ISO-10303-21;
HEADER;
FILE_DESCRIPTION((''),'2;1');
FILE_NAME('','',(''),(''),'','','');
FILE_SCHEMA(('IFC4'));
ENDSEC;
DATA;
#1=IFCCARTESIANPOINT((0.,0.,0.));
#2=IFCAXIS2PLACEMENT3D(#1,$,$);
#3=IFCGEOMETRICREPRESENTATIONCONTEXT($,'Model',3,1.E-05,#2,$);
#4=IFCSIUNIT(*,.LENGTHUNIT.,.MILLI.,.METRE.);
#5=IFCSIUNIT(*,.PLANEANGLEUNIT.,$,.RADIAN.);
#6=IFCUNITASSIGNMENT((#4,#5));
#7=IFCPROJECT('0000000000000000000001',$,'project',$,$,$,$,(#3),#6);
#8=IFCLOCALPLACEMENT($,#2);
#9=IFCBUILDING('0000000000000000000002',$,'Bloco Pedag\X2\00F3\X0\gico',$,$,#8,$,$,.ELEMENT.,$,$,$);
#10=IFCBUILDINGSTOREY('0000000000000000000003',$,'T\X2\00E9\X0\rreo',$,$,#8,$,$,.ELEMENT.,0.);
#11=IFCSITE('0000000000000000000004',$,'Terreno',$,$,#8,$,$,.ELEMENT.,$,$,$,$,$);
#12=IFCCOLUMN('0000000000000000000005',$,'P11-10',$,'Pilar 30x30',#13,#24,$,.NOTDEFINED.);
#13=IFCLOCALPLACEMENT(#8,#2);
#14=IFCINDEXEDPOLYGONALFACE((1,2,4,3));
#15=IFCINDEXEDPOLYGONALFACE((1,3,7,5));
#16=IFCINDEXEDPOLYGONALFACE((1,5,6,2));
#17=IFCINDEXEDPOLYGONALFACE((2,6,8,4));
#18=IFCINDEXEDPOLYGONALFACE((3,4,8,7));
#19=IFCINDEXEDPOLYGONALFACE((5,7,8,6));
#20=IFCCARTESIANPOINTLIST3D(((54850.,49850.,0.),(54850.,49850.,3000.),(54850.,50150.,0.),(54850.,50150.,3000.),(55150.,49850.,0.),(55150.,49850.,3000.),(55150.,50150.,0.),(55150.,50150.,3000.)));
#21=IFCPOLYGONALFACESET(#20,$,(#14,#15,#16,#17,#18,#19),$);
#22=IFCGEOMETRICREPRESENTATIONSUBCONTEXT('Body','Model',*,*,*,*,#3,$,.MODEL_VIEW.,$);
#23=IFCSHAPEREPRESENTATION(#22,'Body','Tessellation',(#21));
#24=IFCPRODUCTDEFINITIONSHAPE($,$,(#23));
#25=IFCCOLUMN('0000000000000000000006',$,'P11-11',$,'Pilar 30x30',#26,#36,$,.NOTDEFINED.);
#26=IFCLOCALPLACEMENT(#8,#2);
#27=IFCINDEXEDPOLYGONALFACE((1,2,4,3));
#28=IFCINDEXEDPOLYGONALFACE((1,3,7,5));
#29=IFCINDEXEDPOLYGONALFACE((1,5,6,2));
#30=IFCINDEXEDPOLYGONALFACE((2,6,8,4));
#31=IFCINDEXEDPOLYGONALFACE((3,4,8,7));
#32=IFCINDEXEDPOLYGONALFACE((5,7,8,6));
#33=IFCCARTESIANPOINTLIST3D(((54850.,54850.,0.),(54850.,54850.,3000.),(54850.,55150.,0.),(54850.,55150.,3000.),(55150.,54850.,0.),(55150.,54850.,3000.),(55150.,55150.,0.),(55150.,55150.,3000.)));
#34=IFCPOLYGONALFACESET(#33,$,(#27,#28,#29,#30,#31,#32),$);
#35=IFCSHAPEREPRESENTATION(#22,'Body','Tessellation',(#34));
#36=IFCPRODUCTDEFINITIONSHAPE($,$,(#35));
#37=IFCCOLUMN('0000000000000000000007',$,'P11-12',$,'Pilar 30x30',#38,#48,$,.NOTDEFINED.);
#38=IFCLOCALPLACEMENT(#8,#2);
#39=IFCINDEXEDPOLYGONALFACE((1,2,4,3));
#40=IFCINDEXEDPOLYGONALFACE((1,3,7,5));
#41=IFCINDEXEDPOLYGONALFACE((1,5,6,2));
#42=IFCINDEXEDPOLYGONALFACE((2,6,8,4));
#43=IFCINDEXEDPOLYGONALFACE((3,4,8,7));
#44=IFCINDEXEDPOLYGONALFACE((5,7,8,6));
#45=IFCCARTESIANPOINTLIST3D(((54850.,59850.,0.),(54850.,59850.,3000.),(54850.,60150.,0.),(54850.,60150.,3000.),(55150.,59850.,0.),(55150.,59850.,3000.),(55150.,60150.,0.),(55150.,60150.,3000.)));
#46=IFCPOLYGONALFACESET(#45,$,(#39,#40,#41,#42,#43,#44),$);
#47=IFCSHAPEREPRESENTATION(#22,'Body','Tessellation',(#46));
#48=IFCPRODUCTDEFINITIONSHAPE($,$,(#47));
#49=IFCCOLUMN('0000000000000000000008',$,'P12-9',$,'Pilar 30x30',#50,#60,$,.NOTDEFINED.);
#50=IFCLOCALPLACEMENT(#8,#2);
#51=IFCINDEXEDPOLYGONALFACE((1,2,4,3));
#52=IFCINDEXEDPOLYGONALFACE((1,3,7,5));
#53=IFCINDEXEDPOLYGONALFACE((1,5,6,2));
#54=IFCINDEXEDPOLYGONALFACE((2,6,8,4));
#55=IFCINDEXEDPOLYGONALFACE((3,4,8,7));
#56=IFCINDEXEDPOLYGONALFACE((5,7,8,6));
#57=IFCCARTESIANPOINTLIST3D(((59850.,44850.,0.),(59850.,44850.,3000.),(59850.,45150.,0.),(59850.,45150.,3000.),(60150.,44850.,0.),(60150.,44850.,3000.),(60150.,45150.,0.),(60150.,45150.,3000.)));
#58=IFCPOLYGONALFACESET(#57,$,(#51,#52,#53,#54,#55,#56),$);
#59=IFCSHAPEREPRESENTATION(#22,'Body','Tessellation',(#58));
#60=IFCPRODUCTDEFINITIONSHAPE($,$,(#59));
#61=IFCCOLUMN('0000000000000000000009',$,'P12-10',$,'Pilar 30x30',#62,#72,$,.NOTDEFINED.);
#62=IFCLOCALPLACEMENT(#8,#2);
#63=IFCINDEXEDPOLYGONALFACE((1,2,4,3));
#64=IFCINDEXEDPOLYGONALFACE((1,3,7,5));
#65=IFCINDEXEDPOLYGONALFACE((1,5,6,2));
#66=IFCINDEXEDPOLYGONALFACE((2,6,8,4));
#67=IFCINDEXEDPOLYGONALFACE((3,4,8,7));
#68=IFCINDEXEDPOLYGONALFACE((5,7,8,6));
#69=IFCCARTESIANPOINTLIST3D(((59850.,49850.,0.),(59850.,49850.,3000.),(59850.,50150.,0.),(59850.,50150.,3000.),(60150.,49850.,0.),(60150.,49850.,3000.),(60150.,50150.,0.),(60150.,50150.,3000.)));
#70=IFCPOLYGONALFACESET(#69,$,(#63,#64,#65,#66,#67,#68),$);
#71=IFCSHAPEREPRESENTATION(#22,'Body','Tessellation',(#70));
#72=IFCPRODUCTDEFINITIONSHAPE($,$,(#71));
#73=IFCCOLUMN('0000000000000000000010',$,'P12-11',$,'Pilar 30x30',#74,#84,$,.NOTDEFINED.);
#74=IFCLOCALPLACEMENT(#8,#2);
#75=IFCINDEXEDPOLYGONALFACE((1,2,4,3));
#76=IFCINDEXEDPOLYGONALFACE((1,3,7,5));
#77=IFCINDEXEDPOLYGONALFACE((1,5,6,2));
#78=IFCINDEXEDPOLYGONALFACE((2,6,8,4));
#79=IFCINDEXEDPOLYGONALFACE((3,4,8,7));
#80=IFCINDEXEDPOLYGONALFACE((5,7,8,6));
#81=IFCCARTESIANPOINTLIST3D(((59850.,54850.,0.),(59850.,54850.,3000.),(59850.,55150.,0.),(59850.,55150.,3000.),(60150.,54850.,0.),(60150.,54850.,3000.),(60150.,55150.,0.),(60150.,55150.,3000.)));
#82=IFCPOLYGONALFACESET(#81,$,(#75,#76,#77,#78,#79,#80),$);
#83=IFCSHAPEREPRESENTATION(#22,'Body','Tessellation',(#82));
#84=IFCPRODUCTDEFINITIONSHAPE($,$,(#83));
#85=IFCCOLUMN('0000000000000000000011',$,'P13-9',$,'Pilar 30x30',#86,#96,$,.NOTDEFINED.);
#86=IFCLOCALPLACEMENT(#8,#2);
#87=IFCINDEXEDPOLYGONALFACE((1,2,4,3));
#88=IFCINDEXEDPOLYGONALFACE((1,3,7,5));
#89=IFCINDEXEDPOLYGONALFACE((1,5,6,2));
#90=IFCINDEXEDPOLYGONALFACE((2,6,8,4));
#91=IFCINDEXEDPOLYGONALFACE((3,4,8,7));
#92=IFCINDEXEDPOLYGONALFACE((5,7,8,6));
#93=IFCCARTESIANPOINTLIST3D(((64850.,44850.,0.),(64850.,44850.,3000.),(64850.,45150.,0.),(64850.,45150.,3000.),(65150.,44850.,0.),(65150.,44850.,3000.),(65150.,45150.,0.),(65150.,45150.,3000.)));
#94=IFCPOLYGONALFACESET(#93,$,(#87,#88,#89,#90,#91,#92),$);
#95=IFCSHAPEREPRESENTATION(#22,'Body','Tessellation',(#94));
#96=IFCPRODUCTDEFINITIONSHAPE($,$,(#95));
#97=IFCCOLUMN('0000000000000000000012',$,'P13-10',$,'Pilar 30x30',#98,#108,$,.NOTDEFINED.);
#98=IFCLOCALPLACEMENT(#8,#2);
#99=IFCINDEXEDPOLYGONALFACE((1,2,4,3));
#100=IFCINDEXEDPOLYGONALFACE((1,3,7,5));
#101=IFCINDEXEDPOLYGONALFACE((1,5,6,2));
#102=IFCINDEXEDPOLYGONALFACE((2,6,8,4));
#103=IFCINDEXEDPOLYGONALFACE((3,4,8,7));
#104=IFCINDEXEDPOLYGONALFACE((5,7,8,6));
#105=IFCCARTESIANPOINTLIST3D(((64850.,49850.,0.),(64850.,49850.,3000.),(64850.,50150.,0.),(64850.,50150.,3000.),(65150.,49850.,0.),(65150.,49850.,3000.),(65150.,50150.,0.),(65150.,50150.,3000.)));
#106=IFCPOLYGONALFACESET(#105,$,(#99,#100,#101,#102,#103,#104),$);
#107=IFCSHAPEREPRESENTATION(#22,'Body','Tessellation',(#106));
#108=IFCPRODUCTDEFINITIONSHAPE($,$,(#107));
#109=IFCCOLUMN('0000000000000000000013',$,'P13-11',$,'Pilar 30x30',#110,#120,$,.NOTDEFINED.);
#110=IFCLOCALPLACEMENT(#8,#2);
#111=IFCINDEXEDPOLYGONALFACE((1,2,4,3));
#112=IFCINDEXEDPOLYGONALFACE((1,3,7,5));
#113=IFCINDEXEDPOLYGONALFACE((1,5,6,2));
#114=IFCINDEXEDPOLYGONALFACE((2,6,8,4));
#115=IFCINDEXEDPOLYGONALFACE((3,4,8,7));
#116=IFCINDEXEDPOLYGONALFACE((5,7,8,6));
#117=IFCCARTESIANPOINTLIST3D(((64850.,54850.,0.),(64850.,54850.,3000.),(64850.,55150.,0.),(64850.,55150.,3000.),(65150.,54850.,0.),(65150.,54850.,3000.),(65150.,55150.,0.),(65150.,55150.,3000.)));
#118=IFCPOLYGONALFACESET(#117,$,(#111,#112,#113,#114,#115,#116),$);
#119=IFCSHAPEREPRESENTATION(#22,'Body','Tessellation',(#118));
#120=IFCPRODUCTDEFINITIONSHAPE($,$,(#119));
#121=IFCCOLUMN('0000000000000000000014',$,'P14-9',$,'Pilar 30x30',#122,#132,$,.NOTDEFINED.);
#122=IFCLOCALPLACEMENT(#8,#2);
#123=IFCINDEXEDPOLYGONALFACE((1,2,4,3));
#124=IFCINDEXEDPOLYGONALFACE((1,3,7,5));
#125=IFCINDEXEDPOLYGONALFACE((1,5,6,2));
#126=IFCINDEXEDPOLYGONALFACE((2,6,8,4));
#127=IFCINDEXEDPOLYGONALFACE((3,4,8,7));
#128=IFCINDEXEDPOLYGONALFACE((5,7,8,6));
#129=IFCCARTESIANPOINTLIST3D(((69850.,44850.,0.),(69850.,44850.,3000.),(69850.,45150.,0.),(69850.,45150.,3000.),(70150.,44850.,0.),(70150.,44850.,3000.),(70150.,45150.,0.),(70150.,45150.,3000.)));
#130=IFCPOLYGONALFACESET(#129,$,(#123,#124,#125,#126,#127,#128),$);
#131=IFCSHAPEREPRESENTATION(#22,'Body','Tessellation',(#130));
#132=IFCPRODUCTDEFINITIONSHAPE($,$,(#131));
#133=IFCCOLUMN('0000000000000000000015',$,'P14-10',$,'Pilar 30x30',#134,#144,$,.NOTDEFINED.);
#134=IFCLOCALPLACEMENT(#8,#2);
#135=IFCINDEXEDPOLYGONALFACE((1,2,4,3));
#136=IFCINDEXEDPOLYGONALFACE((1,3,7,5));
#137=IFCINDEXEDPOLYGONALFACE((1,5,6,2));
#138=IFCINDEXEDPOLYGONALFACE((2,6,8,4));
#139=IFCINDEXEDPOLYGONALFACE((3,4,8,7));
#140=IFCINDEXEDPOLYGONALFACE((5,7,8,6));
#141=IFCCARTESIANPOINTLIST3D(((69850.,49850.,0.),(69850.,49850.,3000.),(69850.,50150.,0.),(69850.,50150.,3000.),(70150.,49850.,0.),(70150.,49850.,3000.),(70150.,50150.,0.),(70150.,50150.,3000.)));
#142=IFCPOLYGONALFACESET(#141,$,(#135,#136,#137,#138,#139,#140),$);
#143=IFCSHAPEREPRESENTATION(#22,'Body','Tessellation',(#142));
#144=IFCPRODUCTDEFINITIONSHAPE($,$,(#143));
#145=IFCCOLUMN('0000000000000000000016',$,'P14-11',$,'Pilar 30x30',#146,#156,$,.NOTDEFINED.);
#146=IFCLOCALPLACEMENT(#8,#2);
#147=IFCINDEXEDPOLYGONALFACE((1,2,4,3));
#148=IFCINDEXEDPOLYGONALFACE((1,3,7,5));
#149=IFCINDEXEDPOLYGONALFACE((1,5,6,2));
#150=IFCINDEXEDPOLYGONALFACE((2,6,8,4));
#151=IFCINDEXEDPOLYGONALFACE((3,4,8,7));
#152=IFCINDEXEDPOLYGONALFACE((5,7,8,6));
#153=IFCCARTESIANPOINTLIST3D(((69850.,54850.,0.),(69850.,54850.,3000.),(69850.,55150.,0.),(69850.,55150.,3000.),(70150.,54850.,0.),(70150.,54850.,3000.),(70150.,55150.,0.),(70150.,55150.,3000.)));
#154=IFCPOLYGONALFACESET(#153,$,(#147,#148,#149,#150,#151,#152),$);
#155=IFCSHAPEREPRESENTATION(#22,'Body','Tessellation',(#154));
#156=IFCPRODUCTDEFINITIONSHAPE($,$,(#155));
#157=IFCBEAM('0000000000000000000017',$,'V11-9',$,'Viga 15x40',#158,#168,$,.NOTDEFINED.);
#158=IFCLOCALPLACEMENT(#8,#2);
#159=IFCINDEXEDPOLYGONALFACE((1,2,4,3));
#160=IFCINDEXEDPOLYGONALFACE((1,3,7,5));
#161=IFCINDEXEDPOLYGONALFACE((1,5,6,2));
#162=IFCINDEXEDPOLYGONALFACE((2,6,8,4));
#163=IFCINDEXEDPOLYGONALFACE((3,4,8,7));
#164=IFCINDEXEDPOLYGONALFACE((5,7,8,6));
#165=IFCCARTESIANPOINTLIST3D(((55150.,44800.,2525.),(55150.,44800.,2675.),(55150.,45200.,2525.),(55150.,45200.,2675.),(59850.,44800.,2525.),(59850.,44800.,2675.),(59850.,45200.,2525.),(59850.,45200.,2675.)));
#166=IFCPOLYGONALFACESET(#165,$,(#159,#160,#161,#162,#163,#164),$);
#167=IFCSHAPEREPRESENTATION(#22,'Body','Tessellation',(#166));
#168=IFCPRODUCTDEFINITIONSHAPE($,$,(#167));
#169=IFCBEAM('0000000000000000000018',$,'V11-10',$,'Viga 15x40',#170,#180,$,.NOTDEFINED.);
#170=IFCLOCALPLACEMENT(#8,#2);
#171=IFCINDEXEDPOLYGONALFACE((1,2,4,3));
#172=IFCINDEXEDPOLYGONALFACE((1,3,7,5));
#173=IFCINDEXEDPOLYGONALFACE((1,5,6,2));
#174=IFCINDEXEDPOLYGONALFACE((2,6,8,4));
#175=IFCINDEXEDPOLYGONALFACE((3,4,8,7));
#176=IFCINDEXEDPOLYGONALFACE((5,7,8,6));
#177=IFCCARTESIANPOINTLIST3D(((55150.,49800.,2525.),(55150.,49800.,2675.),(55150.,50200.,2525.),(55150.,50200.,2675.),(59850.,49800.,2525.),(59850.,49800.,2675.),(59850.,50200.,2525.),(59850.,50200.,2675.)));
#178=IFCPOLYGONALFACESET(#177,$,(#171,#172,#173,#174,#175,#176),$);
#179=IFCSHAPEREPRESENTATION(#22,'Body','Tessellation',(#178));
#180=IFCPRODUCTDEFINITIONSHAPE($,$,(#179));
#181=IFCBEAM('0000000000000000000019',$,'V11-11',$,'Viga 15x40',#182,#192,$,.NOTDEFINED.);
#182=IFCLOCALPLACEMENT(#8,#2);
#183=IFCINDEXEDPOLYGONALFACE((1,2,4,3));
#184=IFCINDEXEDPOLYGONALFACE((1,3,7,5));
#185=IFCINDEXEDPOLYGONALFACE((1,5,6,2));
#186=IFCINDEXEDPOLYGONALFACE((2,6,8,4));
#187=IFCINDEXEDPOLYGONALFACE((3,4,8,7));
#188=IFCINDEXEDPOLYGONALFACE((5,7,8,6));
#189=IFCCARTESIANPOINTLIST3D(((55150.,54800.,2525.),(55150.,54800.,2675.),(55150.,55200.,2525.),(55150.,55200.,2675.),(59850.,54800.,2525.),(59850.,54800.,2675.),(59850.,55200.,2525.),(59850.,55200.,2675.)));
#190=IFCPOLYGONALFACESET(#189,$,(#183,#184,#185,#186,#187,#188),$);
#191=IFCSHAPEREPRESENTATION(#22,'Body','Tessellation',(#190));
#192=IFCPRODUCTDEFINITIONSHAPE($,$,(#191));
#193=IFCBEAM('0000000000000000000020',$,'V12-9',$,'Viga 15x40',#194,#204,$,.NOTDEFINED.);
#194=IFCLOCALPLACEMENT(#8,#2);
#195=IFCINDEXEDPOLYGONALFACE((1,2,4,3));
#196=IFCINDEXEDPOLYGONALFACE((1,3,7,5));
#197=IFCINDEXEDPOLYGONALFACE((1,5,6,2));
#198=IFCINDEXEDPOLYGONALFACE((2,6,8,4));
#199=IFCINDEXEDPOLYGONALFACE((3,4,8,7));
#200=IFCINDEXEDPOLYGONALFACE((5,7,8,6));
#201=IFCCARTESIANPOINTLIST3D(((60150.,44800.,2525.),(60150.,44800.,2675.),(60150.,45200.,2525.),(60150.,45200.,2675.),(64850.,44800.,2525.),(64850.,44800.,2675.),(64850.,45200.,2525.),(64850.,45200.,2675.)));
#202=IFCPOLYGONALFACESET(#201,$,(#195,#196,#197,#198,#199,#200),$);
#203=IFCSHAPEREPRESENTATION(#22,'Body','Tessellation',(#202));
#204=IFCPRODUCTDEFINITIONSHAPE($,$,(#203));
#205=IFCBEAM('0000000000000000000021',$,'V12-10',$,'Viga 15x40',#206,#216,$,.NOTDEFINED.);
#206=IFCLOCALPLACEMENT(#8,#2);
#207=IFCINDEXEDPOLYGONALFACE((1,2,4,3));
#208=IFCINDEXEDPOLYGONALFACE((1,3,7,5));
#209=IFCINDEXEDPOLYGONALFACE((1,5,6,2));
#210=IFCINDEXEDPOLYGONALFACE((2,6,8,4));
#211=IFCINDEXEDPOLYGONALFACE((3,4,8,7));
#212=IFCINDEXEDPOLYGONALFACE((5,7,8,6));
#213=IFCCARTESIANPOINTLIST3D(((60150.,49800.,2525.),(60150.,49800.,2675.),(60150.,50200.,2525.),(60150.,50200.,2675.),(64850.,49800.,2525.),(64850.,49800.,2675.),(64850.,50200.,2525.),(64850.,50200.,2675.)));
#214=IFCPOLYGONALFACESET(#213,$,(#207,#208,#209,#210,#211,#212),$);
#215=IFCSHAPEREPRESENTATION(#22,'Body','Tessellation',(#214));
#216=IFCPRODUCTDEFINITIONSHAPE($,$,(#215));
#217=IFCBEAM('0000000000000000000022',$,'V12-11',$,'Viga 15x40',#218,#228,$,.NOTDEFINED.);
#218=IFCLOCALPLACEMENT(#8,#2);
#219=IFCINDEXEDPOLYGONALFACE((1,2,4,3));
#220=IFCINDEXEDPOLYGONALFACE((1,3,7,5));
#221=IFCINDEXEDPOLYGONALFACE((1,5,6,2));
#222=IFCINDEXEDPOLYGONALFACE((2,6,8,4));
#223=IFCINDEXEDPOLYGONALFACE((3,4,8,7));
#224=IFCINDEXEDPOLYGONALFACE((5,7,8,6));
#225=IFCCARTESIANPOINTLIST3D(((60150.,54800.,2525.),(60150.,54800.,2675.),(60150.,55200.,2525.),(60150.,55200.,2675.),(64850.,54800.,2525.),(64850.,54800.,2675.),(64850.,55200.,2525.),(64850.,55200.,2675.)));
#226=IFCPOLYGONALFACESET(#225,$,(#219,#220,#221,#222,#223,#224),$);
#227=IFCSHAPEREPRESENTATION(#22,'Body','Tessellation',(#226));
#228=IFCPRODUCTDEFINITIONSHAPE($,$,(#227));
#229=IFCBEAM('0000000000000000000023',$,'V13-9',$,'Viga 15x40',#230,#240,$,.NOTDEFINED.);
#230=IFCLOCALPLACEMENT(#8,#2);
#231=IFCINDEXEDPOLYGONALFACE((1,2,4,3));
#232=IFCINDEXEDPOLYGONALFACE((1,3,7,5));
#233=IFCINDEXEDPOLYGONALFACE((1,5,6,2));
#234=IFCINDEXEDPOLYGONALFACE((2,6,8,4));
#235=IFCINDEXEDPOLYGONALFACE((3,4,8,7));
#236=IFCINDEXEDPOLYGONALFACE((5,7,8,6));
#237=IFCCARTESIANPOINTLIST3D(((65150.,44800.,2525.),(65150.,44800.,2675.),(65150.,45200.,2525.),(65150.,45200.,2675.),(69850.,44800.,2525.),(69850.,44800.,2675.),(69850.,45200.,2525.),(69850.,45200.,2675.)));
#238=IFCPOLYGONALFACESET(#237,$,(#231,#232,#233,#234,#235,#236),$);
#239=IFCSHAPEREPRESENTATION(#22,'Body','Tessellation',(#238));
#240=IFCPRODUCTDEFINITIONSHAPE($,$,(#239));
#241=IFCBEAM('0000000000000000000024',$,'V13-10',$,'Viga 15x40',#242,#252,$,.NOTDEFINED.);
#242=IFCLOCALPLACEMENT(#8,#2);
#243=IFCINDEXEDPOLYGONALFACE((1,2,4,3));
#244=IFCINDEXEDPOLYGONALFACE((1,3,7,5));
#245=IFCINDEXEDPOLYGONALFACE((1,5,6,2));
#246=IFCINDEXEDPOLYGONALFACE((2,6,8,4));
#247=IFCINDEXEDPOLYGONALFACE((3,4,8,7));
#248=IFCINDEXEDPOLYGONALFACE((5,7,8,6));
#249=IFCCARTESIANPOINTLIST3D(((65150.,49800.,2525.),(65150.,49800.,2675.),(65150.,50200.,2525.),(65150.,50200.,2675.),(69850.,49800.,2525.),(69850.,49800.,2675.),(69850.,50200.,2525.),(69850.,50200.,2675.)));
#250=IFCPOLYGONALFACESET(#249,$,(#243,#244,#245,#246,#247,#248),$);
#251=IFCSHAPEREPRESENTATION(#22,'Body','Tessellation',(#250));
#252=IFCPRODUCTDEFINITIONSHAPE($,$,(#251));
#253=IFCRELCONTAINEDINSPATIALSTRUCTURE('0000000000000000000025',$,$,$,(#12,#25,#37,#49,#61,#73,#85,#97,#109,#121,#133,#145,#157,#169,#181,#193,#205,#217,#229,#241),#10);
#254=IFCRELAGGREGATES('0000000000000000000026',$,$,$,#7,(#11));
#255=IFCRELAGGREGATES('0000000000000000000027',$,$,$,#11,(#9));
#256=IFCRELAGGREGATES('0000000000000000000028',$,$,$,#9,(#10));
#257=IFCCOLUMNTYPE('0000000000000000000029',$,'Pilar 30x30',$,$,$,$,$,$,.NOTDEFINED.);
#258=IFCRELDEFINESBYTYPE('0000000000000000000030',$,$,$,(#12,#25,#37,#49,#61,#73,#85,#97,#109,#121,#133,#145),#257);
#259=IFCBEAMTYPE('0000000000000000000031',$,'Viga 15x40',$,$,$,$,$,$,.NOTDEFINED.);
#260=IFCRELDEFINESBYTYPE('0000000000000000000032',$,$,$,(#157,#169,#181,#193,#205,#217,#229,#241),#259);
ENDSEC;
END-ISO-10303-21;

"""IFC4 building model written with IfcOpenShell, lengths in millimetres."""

from ifc_helpers import new_model, si_unit, frame, origin, origin_2d, place, context, subcontext, project, spatial, rectangle, extrude, type_object, element, save


model = new_model("IFC4")

# Units and contexts
model_context = context("Model", 3, precision=1e-05, world=origin())
body_context = subcontext(model_context, "Body", "Model", "MODEL_VIEW")
ifc_project = project(units=[si_unit("LENGTHUNIT", "METRE", prefix="MILLI"), si_unit("PLANEANGLEUNIT", "RADIAN")], contexts=[model_context])

# Site, building, storey
placement = place(None, origin())
site = spatial("IfcSite", under=ifc_project, at=placement, Name="Terreno", CompositionType="ELEMENT")
building = spatial("IfcBuilding", under=site, at=placement, Name="Bloco Pedagógico", CompositionType="ELEMENT")
storey = spatial("IfcBuildingStorey", under=building, at=placement, Name="Térreo", CompositionType="ELEMENT", Elevation=0.0)

# Columns
column_type = type_object("IfcColumnType", Name="Pilar 30x30", PredefinedType="NOTDEFINED")
for number, where, z_axis, x_axis, name in (
    (1, (55000.0, 50000.0, 0.0), (0.0, 0.0, 1.0), (1.0, 0.0, 0.0), "P11-10"),
    (2, (55000.0, 55000.0, 0.0), (0.0, 0.0, 1.0), (1.0, 0.0, 0.0), "P11-11"),
    (3, (55000.0, 60000.0, 0.0), (0.0, 0.0, 1.0), (1.0, 0.0, 0.0), "P11-12"),
    (4, (60000.0, 45000.0, 0.0), (0.0, 0.0, 1.0), (1.0, 0.0, 0.0), "P12-9"),
    (5, (60000.0, 50000.0, 0.0), (0.0, 0.0, 1.0), (1.0, 0.0, 0.0), "P12-10"),
    (6, (60000.0, 55000.0, 0.0), (0.0, 0.0, 1.0), (1.0, 0.0, 0.0), "P12-11"),
    (7, (65000.0, 45000.0, 0.0), (0.0, 0.0, 1.0), (1.0, 0.0, 0.0), "P13-9"),
    (8, (65000.0, 50000.0, 0.0), (0.0, 0.0, 1.0), (1.0, 0.0, 0.0), "P13-10"),
    (9, (65000.0, 55000.0, 0.0), (0.0, 0.0, 1.0), (1.0, 0.0, 0.0), "P13-11"),
    (10, (70000.0, 45000.0, 0.0), (0.0, 0.0, 1.0), (1.0, 0.0, 0.0), "P14-9"),
    (11, (70000.0, 50000.0, 0.0), (0.0, 0.0, 1.0), (1.0, 0.0, 0.0), "P14-10"),
    (12, (70000.0, 55000.0, 0.0), (0.0, 0.0, 1.0), (1.0, 0.0, 0.0), "P14-11"),
):
    element("IfcColumn", number, at=place(None, frame(where, z_axis=z_axis, x_axis=x_axis)), inside=storey, type_object=column_type, Name=name, ObjectType="Pilar 30x30", PredefinedType="NOTDEFINED", context=body_context, shape_type="SweptSolid", body=[
        extrude(rectangle(XDim=300.0, YDim=300.0, at=origin_2d()), None, (0.0, 0.0, 1.0), 3000.0),
    ])

# Beams
beam_type = type_object("IfcBeamType", Name="Viga 15x40", PredefinedType="NOTDEFINED")
for number, where, z_axis, x_axis, name in (
    (13, (55150.0, 45000.0, 2600.0), (1.0, 0.0, 0.0), (0.0, 1.0, 0.0), "V11-9"),
    (14, (55150.0, 50000.0, 2600.0), (1.0, 0.0, 0.0), (0.0, 1.0, 0.0), "V11-10"),
    (15, (55150.0, 55000.0, 2600.0), (1.0, 0.0, 0.0), (0.0, 1.0, 0.0), "V11-11"),
    (16, (60150.0, 45000.0, 2600.0), (1.0, 0.0, 0.0), (0.0, 1.0, 0.0), "V12-9"),
    (17, (60150.0, 50000.0, 2600.0), (1.0, 0.0, 0.0), (0.0, 1.0, 0.0), "V12-10"),
    (18, (60150.0, 55000.0, 2600.0), (1.0, 0.0, 0.0), (0.0, 1.0, 0.0), "V12-11"),
    (19, (65150.0, 45000.0, 2600.0), (1.0, 0.0, 0.0), (0.0, 1.0, 0.0), "V13-9"),
    (20, (65150.0, 50000.0, 2600.0), (1.0, 0.0, 0.0), (0.0, 1.0, 0.0), "V13-10"),
):
    element("IfcBeam", number, at=place(None, frame(where, z_axis=z_axis, x_axis=x_axis)), inside=storey, type_object=beam_type, Name=name, ObjectType="Viga 15x40", PredefinedType="NOTDEFINED", context=body_context, shape_type="SweptSolid", body=[
        extrude(rectangle(XDim=400.0, YDim=150.0, at=origin_2d()), None, (0.0, 0.0, 1.0), 4700.0),
    ])

save(model, "model.ifc")
